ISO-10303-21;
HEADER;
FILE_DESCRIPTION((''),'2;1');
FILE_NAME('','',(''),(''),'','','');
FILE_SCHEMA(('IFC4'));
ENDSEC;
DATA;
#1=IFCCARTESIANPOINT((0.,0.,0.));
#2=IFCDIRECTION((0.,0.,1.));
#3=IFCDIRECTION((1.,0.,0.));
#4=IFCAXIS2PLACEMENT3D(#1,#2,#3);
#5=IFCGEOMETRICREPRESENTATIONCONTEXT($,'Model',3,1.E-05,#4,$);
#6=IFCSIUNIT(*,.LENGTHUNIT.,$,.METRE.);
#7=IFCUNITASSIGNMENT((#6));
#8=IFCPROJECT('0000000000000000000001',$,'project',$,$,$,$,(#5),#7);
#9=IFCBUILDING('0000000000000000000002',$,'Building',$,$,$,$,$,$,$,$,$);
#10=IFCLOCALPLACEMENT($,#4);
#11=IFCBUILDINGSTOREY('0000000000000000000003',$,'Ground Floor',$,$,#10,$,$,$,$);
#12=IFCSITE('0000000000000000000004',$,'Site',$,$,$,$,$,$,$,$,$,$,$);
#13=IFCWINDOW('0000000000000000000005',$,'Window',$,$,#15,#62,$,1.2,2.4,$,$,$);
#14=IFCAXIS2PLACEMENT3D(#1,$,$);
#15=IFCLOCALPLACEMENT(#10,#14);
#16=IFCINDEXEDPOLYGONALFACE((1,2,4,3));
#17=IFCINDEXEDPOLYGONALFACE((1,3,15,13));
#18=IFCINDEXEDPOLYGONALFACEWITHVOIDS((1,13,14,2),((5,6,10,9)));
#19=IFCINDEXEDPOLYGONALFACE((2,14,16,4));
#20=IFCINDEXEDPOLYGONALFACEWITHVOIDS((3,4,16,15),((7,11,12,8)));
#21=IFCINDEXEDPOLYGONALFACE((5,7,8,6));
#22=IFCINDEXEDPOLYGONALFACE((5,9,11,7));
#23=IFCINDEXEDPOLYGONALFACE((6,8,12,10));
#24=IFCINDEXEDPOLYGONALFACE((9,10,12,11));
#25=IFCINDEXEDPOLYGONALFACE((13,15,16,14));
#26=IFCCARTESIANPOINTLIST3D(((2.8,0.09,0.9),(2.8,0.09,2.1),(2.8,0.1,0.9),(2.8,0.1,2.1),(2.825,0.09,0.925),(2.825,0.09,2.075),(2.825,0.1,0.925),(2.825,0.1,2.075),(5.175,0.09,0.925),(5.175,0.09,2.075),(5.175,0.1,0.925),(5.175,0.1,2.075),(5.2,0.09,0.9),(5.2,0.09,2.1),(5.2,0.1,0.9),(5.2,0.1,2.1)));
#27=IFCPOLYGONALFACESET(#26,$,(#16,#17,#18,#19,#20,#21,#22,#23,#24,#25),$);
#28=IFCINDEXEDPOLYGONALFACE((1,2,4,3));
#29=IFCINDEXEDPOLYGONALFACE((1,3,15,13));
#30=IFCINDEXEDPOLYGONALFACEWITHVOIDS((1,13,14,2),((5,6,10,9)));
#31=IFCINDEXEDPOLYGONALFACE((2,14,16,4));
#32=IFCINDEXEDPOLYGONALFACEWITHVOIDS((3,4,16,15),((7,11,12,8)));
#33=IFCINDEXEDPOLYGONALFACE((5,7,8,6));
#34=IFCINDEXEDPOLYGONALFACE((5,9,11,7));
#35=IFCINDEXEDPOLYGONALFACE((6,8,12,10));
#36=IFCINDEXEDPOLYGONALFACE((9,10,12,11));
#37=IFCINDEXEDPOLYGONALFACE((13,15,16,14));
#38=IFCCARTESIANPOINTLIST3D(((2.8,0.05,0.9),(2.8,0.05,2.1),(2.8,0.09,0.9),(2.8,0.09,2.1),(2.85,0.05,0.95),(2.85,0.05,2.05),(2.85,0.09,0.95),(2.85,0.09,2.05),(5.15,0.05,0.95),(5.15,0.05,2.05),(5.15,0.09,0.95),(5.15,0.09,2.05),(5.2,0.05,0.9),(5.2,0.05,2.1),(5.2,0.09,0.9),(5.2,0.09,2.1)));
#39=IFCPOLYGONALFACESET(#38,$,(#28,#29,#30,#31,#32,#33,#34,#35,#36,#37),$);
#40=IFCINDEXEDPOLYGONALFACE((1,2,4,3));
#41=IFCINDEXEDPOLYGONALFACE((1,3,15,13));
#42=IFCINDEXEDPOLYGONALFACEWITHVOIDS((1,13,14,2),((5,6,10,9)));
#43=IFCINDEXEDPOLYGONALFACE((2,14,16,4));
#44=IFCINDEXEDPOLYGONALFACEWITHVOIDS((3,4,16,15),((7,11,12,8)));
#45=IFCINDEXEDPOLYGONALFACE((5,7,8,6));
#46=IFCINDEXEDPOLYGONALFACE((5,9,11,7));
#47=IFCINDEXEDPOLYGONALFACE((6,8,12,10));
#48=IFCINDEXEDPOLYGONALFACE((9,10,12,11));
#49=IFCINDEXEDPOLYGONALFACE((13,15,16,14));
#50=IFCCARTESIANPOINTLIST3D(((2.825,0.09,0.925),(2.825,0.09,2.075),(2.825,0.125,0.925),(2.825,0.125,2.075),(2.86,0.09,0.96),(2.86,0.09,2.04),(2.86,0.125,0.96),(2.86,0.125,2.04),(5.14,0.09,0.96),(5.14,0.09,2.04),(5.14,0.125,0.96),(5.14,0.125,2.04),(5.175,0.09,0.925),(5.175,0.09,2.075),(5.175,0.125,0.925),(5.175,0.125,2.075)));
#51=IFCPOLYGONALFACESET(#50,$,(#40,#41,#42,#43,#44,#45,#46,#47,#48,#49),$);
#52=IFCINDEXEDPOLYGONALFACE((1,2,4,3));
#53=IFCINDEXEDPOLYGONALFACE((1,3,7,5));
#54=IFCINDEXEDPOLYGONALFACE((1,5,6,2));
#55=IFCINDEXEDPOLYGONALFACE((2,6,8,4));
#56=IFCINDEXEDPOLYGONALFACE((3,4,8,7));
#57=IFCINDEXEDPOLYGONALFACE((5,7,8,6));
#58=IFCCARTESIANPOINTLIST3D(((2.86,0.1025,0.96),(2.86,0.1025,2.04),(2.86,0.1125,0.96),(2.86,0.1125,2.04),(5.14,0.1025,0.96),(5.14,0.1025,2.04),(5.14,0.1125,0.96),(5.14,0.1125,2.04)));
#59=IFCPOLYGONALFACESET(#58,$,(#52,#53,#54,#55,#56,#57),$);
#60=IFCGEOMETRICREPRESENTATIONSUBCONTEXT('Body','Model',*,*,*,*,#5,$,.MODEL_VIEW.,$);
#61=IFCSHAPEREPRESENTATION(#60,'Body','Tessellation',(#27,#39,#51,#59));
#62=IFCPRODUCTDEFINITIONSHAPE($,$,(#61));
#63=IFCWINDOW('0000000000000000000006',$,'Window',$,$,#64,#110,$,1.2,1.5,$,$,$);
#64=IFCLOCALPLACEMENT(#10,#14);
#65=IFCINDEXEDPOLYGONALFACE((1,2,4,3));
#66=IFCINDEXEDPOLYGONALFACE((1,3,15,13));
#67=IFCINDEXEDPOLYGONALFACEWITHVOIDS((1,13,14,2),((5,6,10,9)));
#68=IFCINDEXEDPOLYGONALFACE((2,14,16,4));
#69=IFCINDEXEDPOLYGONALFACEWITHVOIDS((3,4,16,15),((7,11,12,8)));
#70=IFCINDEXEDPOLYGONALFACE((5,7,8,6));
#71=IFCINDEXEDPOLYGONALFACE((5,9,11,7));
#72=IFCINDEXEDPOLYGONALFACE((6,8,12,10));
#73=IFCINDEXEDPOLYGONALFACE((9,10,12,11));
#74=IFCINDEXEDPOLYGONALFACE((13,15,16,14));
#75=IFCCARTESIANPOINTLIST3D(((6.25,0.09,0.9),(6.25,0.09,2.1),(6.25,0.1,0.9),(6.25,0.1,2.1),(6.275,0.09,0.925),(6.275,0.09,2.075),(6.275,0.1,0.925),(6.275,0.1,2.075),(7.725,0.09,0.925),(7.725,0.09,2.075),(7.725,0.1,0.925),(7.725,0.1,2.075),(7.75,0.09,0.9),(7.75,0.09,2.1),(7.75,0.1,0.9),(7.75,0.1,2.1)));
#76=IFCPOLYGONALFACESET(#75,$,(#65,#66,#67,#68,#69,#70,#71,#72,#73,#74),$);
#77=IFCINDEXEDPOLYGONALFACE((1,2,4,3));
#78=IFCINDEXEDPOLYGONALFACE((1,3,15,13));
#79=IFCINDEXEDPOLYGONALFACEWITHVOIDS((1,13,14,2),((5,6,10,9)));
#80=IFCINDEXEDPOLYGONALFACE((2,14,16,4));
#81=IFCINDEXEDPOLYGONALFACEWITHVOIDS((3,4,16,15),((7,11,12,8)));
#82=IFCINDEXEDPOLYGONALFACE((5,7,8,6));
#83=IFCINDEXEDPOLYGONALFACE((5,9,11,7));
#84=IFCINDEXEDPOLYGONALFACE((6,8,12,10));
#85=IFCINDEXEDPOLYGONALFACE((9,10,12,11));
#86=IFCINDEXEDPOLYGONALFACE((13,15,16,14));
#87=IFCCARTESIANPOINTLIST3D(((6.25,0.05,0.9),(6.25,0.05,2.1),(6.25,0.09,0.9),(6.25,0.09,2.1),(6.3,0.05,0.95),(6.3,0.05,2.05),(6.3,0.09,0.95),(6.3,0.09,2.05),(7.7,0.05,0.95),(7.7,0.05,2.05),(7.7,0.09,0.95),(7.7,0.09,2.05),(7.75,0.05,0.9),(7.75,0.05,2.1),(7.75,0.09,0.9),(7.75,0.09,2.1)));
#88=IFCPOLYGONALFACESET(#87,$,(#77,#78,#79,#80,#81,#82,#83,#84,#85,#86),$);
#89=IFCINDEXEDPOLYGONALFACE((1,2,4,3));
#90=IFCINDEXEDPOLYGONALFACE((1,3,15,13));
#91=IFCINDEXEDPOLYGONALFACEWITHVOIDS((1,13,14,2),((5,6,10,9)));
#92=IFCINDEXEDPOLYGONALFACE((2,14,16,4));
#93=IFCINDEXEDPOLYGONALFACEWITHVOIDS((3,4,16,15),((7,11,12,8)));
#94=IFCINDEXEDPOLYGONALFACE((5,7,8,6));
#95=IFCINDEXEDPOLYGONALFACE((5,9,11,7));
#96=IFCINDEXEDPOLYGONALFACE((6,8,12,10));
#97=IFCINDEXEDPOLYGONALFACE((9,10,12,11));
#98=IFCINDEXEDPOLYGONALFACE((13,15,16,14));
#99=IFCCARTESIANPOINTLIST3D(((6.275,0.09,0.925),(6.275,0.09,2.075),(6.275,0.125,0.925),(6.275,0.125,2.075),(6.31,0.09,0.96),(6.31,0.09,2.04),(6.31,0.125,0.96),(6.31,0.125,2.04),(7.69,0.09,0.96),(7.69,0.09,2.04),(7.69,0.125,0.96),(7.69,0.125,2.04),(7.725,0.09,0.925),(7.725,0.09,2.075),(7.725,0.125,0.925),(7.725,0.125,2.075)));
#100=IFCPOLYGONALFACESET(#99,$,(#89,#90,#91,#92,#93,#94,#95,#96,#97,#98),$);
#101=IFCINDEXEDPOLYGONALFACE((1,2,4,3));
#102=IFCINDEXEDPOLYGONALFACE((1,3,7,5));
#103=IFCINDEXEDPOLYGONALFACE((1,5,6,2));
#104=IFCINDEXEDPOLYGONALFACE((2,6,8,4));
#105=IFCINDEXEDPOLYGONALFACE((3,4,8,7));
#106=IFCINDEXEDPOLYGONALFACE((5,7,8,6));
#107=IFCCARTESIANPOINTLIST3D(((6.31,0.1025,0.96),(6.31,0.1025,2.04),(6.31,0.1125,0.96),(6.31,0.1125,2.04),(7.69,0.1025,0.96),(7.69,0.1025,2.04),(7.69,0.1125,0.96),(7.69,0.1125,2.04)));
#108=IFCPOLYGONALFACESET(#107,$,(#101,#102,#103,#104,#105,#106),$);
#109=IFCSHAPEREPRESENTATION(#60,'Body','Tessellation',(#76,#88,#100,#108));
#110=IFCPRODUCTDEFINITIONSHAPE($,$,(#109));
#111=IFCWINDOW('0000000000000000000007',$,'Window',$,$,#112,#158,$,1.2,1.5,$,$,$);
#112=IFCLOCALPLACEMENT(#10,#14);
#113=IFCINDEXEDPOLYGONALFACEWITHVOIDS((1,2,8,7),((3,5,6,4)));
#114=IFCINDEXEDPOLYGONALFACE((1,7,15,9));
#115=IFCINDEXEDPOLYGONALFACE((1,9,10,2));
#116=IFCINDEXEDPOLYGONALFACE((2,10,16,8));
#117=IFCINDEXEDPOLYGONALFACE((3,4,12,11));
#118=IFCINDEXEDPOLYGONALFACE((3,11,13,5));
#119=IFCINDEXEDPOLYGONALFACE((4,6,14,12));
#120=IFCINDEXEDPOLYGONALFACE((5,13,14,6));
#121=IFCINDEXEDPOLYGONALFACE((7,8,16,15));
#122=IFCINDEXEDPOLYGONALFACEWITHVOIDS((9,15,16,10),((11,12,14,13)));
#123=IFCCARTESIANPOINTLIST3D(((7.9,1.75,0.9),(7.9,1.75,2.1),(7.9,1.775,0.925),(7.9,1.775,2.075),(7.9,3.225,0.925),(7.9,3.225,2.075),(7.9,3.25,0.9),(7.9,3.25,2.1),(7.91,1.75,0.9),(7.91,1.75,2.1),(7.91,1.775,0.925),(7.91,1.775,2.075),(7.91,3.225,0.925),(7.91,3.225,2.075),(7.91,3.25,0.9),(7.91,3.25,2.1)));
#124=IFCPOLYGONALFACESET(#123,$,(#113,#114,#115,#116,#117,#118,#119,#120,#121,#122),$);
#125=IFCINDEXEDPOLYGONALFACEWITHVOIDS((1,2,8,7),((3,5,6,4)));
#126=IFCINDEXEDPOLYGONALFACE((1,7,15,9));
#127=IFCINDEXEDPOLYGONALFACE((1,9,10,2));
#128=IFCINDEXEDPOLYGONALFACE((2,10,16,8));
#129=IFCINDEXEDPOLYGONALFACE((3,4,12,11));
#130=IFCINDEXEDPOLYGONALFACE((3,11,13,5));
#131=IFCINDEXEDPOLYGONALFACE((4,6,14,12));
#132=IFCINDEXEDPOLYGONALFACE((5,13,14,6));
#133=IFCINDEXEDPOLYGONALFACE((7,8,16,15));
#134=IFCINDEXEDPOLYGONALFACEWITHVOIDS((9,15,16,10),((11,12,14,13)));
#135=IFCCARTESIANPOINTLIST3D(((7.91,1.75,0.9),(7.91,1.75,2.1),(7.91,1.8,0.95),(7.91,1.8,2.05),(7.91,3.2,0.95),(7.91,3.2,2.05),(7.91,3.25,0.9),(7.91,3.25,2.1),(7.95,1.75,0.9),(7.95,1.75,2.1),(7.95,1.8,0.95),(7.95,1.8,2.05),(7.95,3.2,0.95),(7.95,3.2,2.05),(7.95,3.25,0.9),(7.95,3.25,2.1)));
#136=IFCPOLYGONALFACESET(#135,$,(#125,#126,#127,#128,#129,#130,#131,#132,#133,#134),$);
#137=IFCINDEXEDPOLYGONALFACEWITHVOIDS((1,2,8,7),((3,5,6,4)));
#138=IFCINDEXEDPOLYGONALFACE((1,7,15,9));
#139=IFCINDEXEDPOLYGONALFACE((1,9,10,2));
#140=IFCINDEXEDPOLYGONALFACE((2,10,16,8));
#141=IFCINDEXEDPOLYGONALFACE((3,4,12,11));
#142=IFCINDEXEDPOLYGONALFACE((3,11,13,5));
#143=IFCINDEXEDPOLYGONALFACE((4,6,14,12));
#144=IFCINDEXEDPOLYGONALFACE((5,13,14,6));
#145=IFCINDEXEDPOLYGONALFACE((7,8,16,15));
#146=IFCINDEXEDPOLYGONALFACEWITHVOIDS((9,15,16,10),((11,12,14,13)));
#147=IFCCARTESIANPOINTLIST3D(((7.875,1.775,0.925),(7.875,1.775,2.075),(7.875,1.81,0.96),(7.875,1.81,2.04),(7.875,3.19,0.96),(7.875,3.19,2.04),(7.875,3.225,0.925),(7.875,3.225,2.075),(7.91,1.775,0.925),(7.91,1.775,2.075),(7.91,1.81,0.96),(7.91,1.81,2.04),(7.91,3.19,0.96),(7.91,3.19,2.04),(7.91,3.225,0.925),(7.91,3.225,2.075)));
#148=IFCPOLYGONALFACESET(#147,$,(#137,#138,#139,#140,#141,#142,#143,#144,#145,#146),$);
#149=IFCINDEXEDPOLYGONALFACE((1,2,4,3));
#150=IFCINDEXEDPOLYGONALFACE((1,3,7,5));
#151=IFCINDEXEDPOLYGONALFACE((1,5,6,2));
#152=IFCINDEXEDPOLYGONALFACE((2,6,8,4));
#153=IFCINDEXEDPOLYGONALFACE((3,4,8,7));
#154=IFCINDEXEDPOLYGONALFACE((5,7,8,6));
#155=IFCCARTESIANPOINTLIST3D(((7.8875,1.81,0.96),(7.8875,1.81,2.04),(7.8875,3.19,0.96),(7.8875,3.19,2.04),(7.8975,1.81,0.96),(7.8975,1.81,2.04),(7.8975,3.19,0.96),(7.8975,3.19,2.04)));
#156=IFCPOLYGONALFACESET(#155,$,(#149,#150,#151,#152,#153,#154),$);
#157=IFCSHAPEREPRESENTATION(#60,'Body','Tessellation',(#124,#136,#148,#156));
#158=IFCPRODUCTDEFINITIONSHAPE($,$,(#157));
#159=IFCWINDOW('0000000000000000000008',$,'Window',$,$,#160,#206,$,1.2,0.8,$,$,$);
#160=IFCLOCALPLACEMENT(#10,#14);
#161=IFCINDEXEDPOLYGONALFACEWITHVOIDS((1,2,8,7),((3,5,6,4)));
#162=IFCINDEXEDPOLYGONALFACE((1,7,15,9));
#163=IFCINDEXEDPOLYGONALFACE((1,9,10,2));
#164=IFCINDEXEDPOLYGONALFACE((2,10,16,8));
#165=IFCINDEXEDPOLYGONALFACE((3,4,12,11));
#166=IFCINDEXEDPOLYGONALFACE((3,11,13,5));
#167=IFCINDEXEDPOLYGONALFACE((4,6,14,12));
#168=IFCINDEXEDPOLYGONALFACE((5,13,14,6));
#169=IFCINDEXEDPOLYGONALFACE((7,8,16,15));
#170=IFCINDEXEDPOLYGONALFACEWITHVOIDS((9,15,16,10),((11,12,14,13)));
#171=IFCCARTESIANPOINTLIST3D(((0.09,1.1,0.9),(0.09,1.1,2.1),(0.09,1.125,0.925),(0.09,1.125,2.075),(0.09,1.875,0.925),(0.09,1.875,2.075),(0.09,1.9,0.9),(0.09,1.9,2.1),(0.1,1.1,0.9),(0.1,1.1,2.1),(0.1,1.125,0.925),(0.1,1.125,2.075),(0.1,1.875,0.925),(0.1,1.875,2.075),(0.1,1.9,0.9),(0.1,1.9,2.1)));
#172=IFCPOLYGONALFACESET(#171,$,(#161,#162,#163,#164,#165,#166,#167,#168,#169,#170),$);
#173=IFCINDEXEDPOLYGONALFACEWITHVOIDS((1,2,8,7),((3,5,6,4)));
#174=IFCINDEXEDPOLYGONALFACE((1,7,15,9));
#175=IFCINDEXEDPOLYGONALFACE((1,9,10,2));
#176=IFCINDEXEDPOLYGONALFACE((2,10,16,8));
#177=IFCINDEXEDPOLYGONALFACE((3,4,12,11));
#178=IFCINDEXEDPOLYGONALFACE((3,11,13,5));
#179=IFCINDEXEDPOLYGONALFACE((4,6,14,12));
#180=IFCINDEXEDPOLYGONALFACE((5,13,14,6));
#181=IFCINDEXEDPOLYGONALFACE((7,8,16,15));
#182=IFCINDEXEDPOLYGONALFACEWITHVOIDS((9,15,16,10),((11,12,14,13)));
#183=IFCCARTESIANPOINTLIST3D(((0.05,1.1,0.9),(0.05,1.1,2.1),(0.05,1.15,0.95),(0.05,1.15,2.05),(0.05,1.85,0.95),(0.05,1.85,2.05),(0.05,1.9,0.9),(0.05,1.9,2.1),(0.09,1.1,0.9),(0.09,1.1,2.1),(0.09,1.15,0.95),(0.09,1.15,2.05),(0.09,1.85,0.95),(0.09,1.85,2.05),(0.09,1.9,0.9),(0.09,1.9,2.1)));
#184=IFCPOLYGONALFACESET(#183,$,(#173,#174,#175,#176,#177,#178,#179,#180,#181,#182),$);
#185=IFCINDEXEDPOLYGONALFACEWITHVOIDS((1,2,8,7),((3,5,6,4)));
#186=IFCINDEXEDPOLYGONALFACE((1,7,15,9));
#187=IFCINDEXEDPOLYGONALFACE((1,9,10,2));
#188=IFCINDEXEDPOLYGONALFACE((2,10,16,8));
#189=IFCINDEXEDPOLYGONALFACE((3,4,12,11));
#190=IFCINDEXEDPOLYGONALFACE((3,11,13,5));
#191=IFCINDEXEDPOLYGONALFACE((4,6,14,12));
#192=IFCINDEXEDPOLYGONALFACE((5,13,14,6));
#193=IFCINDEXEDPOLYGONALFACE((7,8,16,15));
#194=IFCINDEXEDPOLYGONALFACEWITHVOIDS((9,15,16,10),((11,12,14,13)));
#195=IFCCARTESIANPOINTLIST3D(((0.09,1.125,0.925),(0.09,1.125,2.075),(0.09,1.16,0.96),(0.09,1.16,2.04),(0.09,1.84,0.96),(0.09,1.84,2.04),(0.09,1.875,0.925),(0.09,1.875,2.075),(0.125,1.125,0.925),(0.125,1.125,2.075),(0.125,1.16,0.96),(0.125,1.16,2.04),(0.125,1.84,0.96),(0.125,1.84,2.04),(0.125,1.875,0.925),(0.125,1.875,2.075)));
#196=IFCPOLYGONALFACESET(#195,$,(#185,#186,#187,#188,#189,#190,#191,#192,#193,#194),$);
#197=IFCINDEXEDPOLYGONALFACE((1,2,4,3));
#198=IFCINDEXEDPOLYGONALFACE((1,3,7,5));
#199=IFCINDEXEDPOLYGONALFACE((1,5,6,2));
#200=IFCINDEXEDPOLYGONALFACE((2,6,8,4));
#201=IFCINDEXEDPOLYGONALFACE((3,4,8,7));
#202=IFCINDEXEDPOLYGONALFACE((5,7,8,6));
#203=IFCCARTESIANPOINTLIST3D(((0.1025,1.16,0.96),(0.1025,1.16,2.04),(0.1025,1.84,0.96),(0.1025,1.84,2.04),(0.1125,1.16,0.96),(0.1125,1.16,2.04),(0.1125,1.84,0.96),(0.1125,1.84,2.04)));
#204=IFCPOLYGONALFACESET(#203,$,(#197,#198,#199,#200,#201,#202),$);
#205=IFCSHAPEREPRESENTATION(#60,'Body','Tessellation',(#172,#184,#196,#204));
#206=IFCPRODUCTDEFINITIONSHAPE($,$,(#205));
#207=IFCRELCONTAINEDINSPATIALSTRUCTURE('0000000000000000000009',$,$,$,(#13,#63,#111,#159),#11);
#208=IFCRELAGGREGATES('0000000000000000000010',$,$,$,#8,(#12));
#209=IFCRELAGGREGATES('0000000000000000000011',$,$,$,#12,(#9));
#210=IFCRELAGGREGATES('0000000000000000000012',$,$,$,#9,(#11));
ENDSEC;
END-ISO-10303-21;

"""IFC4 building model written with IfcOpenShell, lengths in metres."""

from ifc_helpers import new_model, si_unit, frame, origin_with_axes, place, context, subcontext, project, spatial, line, indexed_curve, outline, extrude, element, save


model = new_model("IFC4")

# Units and contexts
model_context = context("Model", 3, precision=1e-05, world=origin_with_axes())
body_context = subcontext(model_context, "Body", "Model", "MODEL_VIEW")
ifc_project = project(units=[si_unit("LENGTHUNIT", "METRE")], contexts=[model_context])

# Site, building, storey
site = spatial("IfcSite", under=ifc_project, Name="Site")
building = spatial("IfcBuilding", under=site, Name="Building")
storey_placement = place(None, origin_with_axes())
storey = spatial("IfcBuildingStorey", under=building, at=storey_placement, Name="Ground Floor")

# Windows
window_1_placement = place(storey_placement, frame((2.8, 0.0, 0.9), z_axis=(0.0, 0.0, 1.0), x_axis=(1.0, 0.0, 0.0)))
element("IfcWindow", 1, at=window_1_placement, inside=storey, Name="Window", OverallHeight=1.2, OverallWidth=2.4, context=body_context, shape_type="SweptSolid", body=[
    extrude(outline(indexed_curve([(0.0, 0.0), (2.4, 0.0), (2.4, 1.2), (0.0, 1.2)], segments=[line(1, 2, 3, 4, 1)]), holes=[indexed_curve([(0.025, 0.025), (2.375, 0.025), (2.375, 1.175), (0.025, 1.175)], segments=[line(1, 2, 3, 4, 1)])]), frame((0.0, 0.09, 0.0), z_axis=(0.0, -1.0, 0.0), x_axis=(1.0, 0.0, 0.0)), (0.0, 0.0, -1.0), 0.01),
    extrude(outline(indexed_curve([(0.0, 0.0), (2.4, 0.0), (2.4, 1.2), (0.0, 1.2)], segments=[line(1, 2, 3, 4, 1)]), holes=[indexed_curve([(0.05, 0.05), (2.35, 0.05), (2.35, 1.15), (0.05, 1.15)], segments=[line(1, 2, 3, 4, 1)])]), frame((0.0, 0.05, 0.0), z_axis=(0.0, -1.0, 0.0), x_axis=(1.0, 0.0, 0.0)), (0.0, 0.0, -1.0), 0.04),
    extrude(outline(indexed_curve([(0.0, 0.0), (2.35, 0.0), (2.35, 1.15), (0.0, 1.15)], segments=[line(1, 2, 3, 4, 1)]), holes=[indexed_curve([(0.035, 0.035), (2.315, 0.035), (2.315, 1.115), (0.035, 1.115)], segments=[line(1, 2, 3, 4, 1)])]), frame((0.025, 0.09, 0.025), z_axis=(0.0, -1.0, 0.0), x_axis=(1.0, 0.0, 0.0)), (0.0, 0.0, -1.0), 0.035),
    extrude(outline(indexed_curve([(0.035, 0.035), (2.315, 0.035), (2.315, 1.115), (0.035, 1.115)], segments=[line(1, 2, 3, 4, 1)])), frame((0.025, 0.1025, 0.025), z_axis=(0.0, -1.0, 0.0), x_axis=(1.0, 0.0, 0.0)), (0.0, 0.0, -1.0), 0.01),
])
for number, where, z_axis, x_axis, name in (
    (2, (6.25, 0.0, 0.9), (0.0, 0.0, 1.0), (1.0, 0.0, 0.0), "Window"),
    (3, (8.0, 1.75, 0.9), (0.0, 0.0, 1.0), (0.0, 1.0, 0.0), "Window"),
):
    element("IfcWindow", number, at=place(storey_placement, frame(where, z_axis=z_axis, x_axis=x_axis)), inside=storey, Name=name, OverallHeight=1.2, OverallWidth=1.5, context=body_context, shape_type="SweptSolid", body=[
        extrude(outline(indexed_curve([(0.0, 0.0), (1.5, 0.0), (1.5, 1.2), (0.0, 1.2)], segments=[line(1, 2, 3, 4, 1)]), holes=[indexed_curve([(0.025, 0.025), (1.475, 0.025), (1.475, 1.175), (0.025, 1.175)], segments=[line(1, 2, 3, 4, 1)])]), frame((0.0, 0.09, 0.0), z_axis=(0.0, -1.0, 0.0), x_axis=(1.0, 0.0, 0.0)), (0.0, 0.0, -1.0), 0.01),
        extrude(outline(indexed_curve([(0.0, 0.0), (1.5, 0.0), (1.5, 1.2), (0.0, 1.2)], segments=[line(1, 2, 3, 4, 1)]), holes=[indexed_curve([(0.05, 0.05), (1.45, 0.05), (1.45, 1.15), (0.05, 1.15)], segments=[line(1, 2, 3, 4, 1)])]), frame((0.0, 0.05, 0.0), z_axis=(0.0, -1.0, 0.0), x_axis=(1.0, 0.0, 0.0)), (0.0, 0.0, -1.0), 0.04),
        extrude(outline(indexed_curve([(0.0, 0.0), (1.45, 0.0), (1.45, 1.15), (0.0, 1.15)], segments=[line(1, 2, 3, 4, 1)]), holes=[indexed_curve([(0.035, 0.035), (1.415, 0.035), (1.415, 1.115), (0.035, 1.115)], segments=[line(1, 2, 3, 4, 1)])]), frame((0.025, 0.09, 0.025), z_axis=(0.0, -1.0, 0.0), x_axis=(1.0, 0.0, 0.0)), (0.0, 0.0, -1.0), 0.035),
        extrude(outline(indexed_curve([(0.035, 0.035), (1.415, 0.035), (1.415, 1.115), (0.035, 1.115)], segments=[line(1, 2, 3, 4, 1)])), frame((0.025, 0.1025, 0.025), z_axis=(0.0, -1.0, 0.0), x_axis=(1.0, 0.0, 0.0)), (0.0, 0.0, -1.0), 0.01),
    ])
window_2_placement = place(storey_placement, frame((0.0, 1.9, 0.9), z_axis=(0.0, 0.0, 1.0), x_axis=(0.0, -1.0, 0.0)))
element("IfcWindow", 4, at=window_2_placement, inside=storey, Name="Window", OverallHeight=1.2, OverallWidth=0.8, context=body_context, shape_type="SweptSolid", body=[
    extrude(outline(indexed_curve([(0.0, 0.0), (0.8, 0.0), (0.8, 1.2), (0.0, 1.2)], segments=[line(1, 2, 3, 4, 1)]), holes=[indexed_curve([(0.025, 0.025), (0.775, 0.025), (0.775, 1.175), (0.025, 1.175)], segments=[line(1, 2, 3, 4, 1)])]), frame((0.0, 0.09, 0.0), z_axis=(0.0, -1.0, 0.0), x_axis=(1.0, 0.0, 0.0)), (0.0, 0.0, -1.0), 0.01),
    extrude(outline(indexed_curve([(0.0, 0.0), (0.8, 0.0), (0.8, 1.2), (0.0, 1.2)], segments=[line(1, 2, 3, 4, 1)]), holes=[indexed_curve([(0.05, 0.05), (0.75, 0.05), (0.75, 1.15), (0.05, 1.15)], segments=[line(1, 2, 3, 4, 1)])]), frame((0.0, 0.05, 0.0), z_axis=(0.0, -1.0, 0.0), x_axis=(1.0, 0.0, 0.0)), (0.0, 0.0, -1.0), 0.04),
    extrude(outline(indexed_curve([(0.0, 0.0), (0.75, 0.0), (0.75, 1.15), (0.0, 1.15)], segments=[line(1, 2, 3, 4, 1)]), holes=[indexed_curve([(0.035, 0.035), (0.715, 0.035), (0.715, 1.115), (0.035, 1.115)], segments=[line(1, 2, 3, 4, 1)])]), frame((0.025, 0.09, 0.025), z_axis=(0.0, -1.0, 0.0), x_axis=(1.0, 0.0, 0.0)), (0.0, 0.0, -1.0), 0.035),
    extrude(outline(indexed_curve([(0.035, 0.035), (0.715, 0.035), (0.715, 1.115), (0.035, 1.115)], segments=[line(1, 2, 3, 4, 1)])), frame((0.025, 0.1025, 0.025), z_axis=(0.0, -1.0, 0.0), x_axis=(1.0, 0.0, 0.0)), (0.0, 0.0, -1.0), 0.01),
])

save(model, "model.ifc")
